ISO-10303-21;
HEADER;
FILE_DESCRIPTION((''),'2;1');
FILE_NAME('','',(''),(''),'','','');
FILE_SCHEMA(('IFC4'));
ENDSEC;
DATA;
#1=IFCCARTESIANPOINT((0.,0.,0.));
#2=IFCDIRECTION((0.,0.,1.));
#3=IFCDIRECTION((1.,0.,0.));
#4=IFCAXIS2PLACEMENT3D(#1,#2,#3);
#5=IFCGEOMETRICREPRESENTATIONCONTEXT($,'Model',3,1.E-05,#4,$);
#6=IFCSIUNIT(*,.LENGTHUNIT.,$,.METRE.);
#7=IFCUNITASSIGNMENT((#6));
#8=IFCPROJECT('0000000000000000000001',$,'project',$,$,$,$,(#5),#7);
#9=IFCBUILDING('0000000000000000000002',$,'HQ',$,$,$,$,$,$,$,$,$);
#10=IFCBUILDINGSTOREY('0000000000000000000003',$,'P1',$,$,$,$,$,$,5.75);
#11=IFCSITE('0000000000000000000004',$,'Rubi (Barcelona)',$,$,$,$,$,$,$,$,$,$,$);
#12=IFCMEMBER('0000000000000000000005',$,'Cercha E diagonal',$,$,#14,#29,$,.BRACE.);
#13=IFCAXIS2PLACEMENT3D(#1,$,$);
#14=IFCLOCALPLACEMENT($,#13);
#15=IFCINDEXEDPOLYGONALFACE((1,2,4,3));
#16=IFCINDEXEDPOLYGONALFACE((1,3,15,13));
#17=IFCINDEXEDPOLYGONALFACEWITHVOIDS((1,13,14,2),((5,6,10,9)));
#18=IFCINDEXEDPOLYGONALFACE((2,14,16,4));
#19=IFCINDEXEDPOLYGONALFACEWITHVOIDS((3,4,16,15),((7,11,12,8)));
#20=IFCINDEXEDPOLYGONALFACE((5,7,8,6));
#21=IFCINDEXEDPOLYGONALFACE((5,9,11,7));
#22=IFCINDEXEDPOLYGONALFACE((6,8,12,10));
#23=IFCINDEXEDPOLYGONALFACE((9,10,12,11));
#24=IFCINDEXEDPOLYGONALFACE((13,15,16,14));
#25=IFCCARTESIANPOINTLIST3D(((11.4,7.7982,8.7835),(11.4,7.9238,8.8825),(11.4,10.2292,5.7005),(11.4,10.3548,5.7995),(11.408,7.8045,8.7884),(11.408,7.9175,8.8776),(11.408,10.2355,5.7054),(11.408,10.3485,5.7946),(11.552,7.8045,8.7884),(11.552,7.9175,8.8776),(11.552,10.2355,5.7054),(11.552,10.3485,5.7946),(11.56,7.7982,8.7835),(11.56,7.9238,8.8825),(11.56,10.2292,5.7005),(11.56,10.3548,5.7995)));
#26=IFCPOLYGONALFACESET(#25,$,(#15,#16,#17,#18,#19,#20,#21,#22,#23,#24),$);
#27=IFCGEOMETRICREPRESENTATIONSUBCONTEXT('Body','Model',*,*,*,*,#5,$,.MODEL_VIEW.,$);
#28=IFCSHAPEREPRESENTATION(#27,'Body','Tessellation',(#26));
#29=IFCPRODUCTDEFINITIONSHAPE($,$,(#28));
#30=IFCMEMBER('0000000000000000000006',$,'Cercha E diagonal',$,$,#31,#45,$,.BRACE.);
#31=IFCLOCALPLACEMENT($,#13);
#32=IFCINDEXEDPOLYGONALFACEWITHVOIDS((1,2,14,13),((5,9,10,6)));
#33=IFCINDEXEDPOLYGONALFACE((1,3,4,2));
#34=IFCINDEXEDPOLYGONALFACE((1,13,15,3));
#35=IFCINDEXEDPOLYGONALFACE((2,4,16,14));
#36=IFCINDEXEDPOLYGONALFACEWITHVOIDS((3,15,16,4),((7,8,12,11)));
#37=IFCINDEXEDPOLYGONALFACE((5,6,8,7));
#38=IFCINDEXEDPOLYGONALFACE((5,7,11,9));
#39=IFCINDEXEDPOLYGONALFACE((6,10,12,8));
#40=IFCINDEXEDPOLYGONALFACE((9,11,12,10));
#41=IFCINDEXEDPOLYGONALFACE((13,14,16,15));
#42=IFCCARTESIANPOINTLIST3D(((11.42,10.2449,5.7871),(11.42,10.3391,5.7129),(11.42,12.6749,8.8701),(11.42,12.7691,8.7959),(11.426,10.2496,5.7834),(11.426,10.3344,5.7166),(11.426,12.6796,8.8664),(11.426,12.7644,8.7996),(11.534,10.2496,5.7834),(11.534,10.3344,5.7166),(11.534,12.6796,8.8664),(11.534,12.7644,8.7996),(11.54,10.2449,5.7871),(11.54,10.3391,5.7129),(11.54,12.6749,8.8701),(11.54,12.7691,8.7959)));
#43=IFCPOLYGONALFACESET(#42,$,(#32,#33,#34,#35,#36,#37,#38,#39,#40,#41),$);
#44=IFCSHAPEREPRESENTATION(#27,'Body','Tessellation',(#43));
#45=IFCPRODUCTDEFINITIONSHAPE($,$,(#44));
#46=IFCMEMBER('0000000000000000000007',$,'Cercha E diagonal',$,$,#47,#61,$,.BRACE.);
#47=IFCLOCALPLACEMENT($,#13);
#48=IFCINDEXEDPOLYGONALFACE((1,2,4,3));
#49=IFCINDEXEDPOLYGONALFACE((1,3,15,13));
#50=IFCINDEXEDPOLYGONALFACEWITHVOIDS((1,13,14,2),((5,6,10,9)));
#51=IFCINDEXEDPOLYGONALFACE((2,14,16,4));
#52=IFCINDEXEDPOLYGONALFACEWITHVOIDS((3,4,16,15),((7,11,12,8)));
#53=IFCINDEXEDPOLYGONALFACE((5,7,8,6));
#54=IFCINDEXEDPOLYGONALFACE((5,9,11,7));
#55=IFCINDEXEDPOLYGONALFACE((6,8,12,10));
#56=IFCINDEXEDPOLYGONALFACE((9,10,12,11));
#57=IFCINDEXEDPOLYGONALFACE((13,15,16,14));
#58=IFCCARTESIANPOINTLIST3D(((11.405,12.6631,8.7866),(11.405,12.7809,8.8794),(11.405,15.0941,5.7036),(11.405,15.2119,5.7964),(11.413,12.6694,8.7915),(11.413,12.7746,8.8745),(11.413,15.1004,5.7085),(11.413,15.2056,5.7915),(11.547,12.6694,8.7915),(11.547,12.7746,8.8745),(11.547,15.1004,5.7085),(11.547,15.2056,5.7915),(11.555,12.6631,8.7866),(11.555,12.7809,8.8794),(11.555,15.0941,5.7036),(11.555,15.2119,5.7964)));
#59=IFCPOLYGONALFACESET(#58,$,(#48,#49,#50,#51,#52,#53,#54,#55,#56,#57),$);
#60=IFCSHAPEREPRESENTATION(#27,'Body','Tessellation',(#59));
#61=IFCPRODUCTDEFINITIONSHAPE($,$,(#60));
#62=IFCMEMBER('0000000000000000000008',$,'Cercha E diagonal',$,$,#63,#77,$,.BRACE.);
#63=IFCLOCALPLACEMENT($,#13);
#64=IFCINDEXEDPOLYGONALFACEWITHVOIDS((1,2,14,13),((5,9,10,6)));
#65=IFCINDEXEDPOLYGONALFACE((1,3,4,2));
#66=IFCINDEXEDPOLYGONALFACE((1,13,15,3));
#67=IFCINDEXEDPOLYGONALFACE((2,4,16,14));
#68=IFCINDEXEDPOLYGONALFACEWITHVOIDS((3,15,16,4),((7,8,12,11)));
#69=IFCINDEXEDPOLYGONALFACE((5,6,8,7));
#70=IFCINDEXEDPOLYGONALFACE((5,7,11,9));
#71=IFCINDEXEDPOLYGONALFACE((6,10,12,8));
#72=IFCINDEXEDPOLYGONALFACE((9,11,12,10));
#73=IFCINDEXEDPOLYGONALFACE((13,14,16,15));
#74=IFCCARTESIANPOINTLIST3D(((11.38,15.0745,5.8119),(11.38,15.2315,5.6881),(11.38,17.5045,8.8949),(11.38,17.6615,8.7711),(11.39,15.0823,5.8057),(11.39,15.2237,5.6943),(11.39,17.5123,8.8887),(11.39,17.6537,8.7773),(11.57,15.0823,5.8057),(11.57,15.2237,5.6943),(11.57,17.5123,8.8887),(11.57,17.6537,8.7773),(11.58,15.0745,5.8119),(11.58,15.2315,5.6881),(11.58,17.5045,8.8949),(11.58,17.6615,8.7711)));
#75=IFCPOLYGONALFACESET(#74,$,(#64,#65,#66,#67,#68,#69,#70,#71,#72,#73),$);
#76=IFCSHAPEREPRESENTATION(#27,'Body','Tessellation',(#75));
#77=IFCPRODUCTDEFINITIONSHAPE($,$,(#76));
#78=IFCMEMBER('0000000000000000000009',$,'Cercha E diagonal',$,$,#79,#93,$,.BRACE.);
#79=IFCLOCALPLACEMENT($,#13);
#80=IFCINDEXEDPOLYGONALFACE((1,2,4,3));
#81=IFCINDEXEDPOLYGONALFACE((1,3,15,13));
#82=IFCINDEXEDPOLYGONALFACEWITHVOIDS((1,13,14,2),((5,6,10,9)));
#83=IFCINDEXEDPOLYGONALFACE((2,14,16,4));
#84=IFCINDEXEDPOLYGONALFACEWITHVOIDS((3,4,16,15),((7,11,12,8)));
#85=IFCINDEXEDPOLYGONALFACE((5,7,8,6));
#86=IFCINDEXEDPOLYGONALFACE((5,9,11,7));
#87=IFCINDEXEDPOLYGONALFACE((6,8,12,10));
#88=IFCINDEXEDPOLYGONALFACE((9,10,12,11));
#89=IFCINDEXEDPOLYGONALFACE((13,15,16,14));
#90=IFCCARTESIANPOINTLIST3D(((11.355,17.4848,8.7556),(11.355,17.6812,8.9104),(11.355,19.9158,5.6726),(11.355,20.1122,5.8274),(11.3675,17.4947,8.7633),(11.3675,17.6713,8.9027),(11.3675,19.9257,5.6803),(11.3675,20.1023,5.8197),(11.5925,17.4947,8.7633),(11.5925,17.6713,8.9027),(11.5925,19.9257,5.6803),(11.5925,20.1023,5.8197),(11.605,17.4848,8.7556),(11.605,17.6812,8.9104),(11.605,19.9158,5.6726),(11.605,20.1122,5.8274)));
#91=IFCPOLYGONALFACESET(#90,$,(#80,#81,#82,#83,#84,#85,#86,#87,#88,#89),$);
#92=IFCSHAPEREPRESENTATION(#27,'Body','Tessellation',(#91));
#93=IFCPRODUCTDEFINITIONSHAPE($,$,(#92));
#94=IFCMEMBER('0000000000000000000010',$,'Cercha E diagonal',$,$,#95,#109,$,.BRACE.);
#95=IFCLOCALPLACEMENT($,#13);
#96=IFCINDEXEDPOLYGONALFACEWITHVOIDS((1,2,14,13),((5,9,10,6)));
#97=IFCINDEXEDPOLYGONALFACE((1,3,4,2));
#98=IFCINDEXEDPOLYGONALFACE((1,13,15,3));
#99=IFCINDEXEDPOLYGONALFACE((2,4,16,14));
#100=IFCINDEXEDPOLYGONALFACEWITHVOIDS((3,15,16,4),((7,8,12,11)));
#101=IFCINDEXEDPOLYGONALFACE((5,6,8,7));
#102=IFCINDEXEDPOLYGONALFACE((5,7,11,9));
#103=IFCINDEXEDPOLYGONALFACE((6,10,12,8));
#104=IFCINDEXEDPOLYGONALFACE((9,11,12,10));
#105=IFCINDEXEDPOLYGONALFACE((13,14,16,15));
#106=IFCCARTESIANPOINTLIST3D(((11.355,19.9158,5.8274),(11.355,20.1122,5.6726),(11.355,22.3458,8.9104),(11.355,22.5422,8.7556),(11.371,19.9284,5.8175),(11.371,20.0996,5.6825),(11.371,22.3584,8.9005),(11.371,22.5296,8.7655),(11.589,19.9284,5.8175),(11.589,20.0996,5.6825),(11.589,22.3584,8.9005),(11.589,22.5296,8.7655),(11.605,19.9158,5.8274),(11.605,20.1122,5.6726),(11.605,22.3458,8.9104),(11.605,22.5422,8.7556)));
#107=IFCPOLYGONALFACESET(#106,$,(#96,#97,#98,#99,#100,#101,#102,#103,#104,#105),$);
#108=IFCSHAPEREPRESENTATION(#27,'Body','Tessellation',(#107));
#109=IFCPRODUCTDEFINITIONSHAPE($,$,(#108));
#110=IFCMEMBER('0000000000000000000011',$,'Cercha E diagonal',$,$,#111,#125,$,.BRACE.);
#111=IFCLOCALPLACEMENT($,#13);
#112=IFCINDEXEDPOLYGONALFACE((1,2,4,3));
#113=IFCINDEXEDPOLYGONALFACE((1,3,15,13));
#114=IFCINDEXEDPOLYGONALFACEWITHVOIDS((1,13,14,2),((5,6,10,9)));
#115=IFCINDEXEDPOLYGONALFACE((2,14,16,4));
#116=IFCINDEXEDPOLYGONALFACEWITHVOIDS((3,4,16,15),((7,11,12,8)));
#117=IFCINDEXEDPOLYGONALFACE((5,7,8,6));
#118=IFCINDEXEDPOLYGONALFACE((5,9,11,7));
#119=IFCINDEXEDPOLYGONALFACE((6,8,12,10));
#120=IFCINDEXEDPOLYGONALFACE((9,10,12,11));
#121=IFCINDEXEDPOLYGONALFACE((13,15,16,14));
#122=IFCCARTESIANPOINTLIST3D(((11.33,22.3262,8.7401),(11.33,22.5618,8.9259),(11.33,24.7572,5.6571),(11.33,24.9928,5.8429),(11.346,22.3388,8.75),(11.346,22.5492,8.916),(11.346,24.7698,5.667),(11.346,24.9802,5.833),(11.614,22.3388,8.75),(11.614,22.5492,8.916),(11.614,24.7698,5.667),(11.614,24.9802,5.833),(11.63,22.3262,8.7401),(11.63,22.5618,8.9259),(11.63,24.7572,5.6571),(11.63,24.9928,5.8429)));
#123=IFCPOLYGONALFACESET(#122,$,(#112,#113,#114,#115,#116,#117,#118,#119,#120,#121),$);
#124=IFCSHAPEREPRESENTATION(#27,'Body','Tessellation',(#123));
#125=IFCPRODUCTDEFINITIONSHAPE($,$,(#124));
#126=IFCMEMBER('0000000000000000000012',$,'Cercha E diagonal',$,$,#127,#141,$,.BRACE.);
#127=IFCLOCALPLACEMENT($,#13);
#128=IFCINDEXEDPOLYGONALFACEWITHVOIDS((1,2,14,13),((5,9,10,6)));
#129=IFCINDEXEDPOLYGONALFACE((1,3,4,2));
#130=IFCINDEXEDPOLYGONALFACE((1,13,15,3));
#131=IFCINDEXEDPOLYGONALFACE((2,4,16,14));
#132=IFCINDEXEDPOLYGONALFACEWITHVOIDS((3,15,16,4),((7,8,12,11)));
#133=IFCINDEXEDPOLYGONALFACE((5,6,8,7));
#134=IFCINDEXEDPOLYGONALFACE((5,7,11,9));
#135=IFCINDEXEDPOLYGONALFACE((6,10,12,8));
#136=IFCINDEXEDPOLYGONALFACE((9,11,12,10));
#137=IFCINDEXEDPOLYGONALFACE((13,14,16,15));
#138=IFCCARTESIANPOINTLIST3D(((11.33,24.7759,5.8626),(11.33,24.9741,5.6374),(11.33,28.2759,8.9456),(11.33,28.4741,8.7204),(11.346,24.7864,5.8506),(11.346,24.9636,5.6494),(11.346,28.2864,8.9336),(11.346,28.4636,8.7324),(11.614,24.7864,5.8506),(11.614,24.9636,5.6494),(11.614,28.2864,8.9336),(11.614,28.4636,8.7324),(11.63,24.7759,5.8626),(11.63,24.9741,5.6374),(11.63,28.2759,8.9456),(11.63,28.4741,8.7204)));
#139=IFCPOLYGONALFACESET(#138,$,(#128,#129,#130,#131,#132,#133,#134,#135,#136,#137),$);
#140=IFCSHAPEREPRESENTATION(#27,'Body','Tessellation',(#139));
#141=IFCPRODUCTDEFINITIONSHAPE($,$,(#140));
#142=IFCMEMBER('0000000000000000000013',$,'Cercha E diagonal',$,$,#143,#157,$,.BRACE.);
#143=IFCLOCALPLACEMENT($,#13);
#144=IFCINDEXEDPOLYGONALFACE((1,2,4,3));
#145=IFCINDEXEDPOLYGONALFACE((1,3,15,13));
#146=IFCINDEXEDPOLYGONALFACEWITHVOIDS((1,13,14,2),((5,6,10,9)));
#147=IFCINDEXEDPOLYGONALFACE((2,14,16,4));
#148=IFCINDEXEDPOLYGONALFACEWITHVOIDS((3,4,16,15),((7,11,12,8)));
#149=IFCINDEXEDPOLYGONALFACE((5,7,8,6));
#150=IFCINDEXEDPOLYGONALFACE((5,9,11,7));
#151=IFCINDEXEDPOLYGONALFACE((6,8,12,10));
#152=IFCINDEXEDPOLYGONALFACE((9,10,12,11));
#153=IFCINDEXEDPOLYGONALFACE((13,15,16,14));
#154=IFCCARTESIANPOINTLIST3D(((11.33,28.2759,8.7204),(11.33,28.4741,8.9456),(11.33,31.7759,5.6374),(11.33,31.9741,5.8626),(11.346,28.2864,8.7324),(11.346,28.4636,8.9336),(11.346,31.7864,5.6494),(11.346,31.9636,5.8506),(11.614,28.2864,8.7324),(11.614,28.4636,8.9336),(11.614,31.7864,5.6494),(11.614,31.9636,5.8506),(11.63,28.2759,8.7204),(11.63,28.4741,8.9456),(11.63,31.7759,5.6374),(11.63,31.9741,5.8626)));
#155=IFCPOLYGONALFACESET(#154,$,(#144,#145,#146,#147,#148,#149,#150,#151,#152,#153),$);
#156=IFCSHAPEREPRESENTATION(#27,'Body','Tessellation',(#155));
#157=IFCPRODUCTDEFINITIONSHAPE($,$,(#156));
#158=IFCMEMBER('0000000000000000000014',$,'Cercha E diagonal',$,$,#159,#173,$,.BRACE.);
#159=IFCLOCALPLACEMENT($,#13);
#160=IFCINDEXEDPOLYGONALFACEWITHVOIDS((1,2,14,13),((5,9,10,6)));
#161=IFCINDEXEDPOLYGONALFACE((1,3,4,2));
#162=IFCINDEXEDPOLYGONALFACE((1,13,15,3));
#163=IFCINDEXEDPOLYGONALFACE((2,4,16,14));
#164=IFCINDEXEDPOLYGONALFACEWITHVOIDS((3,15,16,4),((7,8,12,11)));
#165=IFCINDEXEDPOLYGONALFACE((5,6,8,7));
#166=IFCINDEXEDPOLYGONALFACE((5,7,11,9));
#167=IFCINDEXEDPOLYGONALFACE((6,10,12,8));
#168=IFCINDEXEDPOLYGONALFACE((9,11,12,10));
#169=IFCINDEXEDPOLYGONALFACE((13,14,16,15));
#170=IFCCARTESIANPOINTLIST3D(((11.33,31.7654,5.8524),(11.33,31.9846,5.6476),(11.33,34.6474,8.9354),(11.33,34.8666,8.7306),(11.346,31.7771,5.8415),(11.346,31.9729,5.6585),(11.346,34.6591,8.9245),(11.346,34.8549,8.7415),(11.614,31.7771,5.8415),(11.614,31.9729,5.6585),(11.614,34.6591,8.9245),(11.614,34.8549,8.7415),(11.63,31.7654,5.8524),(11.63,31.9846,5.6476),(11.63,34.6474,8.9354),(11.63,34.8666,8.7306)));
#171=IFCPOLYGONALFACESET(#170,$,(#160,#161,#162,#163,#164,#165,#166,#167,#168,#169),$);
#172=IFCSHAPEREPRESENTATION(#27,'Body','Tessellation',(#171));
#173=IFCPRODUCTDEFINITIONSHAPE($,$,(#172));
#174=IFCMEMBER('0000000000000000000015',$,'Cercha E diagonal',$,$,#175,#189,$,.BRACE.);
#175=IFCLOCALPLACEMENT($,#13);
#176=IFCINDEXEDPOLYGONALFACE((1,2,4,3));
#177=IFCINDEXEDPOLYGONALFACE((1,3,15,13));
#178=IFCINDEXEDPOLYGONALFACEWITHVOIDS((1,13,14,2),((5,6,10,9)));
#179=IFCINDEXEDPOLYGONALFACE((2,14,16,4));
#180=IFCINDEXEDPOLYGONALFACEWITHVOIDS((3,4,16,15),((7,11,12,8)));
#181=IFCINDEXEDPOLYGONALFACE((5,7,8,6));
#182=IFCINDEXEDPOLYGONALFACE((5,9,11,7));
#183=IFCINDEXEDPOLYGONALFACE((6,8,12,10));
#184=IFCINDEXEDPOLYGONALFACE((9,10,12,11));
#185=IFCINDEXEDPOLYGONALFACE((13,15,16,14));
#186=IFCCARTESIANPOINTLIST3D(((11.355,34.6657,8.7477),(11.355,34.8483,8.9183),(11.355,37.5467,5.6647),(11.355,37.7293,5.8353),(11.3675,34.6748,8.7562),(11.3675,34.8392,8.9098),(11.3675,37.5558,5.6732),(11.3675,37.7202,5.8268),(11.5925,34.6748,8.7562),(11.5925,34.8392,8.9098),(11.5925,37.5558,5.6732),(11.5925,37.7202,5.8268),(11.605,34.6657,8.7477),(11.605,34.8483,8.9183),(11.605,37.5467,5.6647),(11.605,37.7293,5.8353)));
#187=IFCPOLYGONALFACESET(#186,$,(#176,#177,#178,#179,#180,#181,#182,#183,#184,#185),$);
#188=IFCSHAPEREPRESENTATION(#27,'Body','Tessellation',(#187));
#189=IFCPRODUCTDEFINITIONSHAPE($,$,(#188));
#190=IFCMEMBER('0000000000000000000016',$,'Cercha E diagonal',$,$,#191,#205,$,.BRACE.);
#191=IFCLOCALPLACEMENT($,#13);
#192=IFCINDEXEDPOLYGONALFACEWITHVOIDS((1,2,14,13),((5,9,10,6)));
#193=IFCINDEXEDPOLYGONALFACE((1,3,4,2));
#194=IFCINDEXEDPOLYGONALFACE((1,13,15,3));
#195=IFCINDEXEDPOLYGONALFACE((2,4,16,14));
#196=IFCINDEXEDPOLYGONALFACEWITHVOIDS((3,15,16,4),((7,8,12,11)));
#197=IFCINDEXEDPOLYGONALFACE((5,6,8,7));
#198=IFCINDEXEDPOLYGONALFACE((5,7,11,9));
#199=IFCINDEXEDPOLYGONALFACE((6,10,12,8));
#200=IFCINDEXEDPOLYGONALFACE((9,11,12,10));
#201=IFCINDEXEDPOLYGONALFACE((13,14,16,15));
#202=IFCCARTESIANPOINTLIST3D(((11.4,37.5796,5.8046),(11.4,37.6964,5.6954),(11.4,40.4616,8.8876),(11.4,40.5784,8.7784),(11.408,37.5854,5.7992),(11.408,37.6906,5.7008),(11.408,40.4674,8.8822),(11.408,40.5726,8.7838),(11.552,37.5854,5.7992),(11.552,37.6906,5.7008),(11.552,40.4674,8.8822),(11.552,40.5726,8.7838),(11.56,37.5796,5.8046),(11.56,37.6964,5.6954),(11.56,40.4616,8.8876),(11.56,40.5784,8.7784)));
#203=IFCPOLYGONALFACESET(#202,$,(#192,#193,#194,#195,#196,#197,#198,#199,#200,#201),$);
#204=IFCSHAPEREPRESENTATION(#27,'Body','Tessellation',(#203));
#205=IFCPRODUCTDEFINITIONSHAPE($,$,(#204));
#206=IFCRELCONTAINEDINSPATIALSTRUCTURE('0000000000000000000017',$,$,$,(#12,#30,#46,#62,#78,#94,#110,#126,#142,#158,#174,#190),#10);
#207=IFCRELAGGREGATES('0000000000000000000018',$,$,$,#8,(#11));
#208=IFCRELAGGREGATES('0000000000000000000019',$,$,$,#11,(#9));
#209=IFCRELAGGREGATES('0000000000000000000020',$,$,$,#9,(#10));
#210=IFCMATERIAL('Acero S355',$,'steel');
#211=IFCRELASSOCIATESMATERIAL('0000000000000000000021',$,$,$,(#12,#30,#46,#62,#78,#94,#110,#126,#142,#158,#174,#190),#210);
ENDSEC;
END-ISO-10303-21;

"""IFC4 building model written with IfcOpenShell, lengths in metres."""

from ifc_helpers import new_model, si_unit, frame, origin_with_axes, place, context, subcontext, project, spatial, hollow_rectangle, extrude, material, element, save


model = new_model("IFC4")

# Units and contexts
model_context = context("Model", 3, precision=1e-05, world=origin_with_axes())
body_context = subcontext(model_context, "Body", "Model", "MODEL_VIEW")
ifc_project = project(units=[si_unit("LENGTHUNIT", "METRE")], contexts=[model_context])

# Site, building, storey
site = spatial("IfcSite", under=ifc_project, Name="Rubi (Barcelona)")
building = spatial("IfcBuilding", under=site, Name="HQ")
storey = spatial("IfcBuildingStorey", under=building, Name="P1", Elevation=5.75)

# Members
ifc_material = material(Name="Acero S355", Category="steel")
member_1_placement = place(None, origin_with_axes())
element("IfcMember", 1, at=member_1_placement, inside=storey, material=ifc_material, Name="Cercha E diagonal", PredefinedType="BRACE", context=body_context, shape_type="SweptSolid", body=[
    extrude(hollow_rectangle(XDim=0.16, YDim=0.16, WallThickness=0.008), frame((11.48, 10.292, 5.75), z_axis=(0.0, -0.619182, 0.785248), x_axis=(1.0, 0.0, 0.0)), (0.0, 0.0, 1.0), 3.9261),
])
member_2_placement = place(None, origin_with_axes())
element("IfcMember", 2, at=member_2_placement, inside=storey, material=ifc_material, Name="Cercha E diagonal", PredefinedType="BRACE", context=body_context, shape_type="SweptSolid", body=[
    extrude(hollow_rectangle(XDim=0.12, YDim=0.12, WallThickness=0.006), frame((11.48, 10.292, 5.75), z_axis=(0.0, 0.619025, 0.785372), x_axis=(-1.0, 0.0, 0.0)), (0.0, 0.0, 1.0), 3.9255),
])
member_3_placement = place(None, origin_with_axes())
element("IfcMember", 3, at=member_3_placement, inside=storey, material=ifc_material, Name="Cercha E diagonal", PredefinedType="BRACE", context=body_context, shape_type="SweptSolid", body=[
    extrude(hollow_rectangle(XDim=0.15, YDim=0.15, WallThickness=0.008), frame((11.48, 15.153, 5.75), z_axis=(0.0, -0.619182, 0.785248), x_axis=(1.0, 0.0, 0.0)), (0.0, 0.0, 1.0), 3.9261),
])
member_4_placement = place(None, origin_with_axes())
element("IfcMember", 4, at=member_4_placement, inside=storey, material=ifc_material, Name="Cercha E diagonal", PredefinedType="BRACE", context=body_context, shape_type="SweptSolid", body=[
    extrude(hollow_rectangle(XDim=0.2, YDim=0.2, WallThickness=0.01), frame((11.48, 15.153, 5.75), z_axis=(0.0, 0.619025, 0.785372), x_axis=(-1.0, 0.0, 0.0)), (0.0, 0.0, 1.0), 3.9255),
])
member_5_placement = place(None, origin_with_axes())
element("IfcMember", 5, at=member_5_placement, inside=storey, material=ifc_material, Name="Cercha E diagonal", PredefinedType="BRACE", context=body_context, shape_type="SweptSolid", body=[
    extrude(hollow_rectangle(XDim=0.25, YDim=0.25, WallThickness=0.0125), frame((11.48, 20.014, 5.75), z_axis=(0.0, -0.619182, 0.785248), x_axis=(1.0, 0.0, 0.0)), (0.0, 0.0, 1.0), 3.9261),
])
member_6_placement = place(None, origin_with_axes())
element("IfcMember", 6, at=member_6_placement, inside=storey, material=ifc_material, Name="Cercha E diagonal", PredefinedType="BRACE", context=body_context, shape_type="SweptSolid", body=[
    extrude(hollow_rectangle(XDim=0.25, YDim=0.25, WallThickness=0.016), frame((11.48, 20.014, 5.75), z_axis=(0.0, 0.619025, 0.785372), x_axis=(-1.0, 0.0, 0.0)), (0.0, 0.0, 1.0), 3.9255),
])
member_7_placement = place(None, origin_with_axes())
element("IfcMember", 7, at=member_7_placement, inside=storey, material=ifc_material, Name="Cercha E diagonal", PredefinedType="BRACE", context=body_context, shape_type="SweptSolid", body=[
    extrude(hollow_rectangle(XDim=0.3, YDim=0.3, WallThickness=0.016), frame((11.48, 24.875, 5.75), z_axis=(0.0, -0.619182, 0.785248), x_axis=(1.0, 0.0, 0.0)), (0.0, 0.0, 1.0), 3.9261),
])
member_8_placement = place(None, origin_with_axes())
element("IfcMember", 8, at=member_8_placement, inside=storey, material=ifc_material, Name="Cercha E diagonal", PredefinedType="BRACE", context=body_context, shape_type="SweptSolid", body=[
    extrude(hollow_rectangle(XDim=0.3, YDim=0.3, WallThickness=0.016), frame((11.48, 24.875, 5.75), z_axis=(0.0, 0.750394, 0.66099), x_axis=(-1.0, 0.0, 0.0)), (0.0, 0.0, 1.0), 4.6642),
])
member_9_placement = place(None, origin_with_axes())
element("IfcMember", 9, at=member_9_placement, inside=storey, material=ifc_material, Name="Cercha E diagonal", PredefinedType="BRACE", context=body_context, shape_type="SweptSolid", body=[
    extrude(hollow_rectangle(XDim=0.3, YDim=0.3, WallThickness=0.016), frame((11.48, 31.875, 5.75), z_axis=(0.0, -0.750394, 0.66099), x_axis=(1.0, 0.0, 0.0)), (0.0, 0.0, 1.0), 4.6642),
])
member_10_placement = place(None, origin_with_axes())
element("IfcMember", 10, at=member_10_placement, inside=storey, material=ifc_material, Name="Cercha E diagonal", PredefinedType="BRACE", context=body_context, shape_type="SweptSolid", body=[
    extrude(hollow_rectangle(XDim=0.3, YDim=0.3, WallThickness=0.016), frame((11.48, 31.875, 5.75), z_axis=(0.0, 0.682892, 0.730519), x_axis=(-1.0, 0.0, 0.0)), (0.0, 0.0, 1.0), 4.2203),
])
member_11_placement = place(None, origin_with_axes())
element("IfcMember", 11, at=member_11_placement, inside=storey, material=ifc_material, Name="Cercha E diagonal", PredefinedType="BRACE", context=body_context, shape_type="SweptSolid", body=[
    extrude(hollow_rectangle(XDim=0.25, YDim=0.25, WallThickness=0.0125), frame((11.48, 37.638, 5.75), z_axis=(0.0, -0.682766, 0.730637), x_axis=(1.0, 0.0, 0.0)), (0.0, 0.0, 1.0), 4.2196),
])
member_12_placement = place(None, origin_with_axes())
element("IfcMember", 12, at=member_12_placement, inside=storey, material=ifc_material, Name="Cercha E diagonal", PredefinedType="BRACE", context=body_context, shape_type="SweptSolid", body=[
    extrude(hollow_rectangle(XDim=0.16, YDim=0.16, WallThickness=0.008), frame((11.48, 37.638, 5.75), z_axis=(0.0, 0.682892, 0.730519), x_axis=(-1.0, 0.0, 0.0)), (0.0, 0.0, 1.0), 4.2203),
])

save(model, "model.ifc")
